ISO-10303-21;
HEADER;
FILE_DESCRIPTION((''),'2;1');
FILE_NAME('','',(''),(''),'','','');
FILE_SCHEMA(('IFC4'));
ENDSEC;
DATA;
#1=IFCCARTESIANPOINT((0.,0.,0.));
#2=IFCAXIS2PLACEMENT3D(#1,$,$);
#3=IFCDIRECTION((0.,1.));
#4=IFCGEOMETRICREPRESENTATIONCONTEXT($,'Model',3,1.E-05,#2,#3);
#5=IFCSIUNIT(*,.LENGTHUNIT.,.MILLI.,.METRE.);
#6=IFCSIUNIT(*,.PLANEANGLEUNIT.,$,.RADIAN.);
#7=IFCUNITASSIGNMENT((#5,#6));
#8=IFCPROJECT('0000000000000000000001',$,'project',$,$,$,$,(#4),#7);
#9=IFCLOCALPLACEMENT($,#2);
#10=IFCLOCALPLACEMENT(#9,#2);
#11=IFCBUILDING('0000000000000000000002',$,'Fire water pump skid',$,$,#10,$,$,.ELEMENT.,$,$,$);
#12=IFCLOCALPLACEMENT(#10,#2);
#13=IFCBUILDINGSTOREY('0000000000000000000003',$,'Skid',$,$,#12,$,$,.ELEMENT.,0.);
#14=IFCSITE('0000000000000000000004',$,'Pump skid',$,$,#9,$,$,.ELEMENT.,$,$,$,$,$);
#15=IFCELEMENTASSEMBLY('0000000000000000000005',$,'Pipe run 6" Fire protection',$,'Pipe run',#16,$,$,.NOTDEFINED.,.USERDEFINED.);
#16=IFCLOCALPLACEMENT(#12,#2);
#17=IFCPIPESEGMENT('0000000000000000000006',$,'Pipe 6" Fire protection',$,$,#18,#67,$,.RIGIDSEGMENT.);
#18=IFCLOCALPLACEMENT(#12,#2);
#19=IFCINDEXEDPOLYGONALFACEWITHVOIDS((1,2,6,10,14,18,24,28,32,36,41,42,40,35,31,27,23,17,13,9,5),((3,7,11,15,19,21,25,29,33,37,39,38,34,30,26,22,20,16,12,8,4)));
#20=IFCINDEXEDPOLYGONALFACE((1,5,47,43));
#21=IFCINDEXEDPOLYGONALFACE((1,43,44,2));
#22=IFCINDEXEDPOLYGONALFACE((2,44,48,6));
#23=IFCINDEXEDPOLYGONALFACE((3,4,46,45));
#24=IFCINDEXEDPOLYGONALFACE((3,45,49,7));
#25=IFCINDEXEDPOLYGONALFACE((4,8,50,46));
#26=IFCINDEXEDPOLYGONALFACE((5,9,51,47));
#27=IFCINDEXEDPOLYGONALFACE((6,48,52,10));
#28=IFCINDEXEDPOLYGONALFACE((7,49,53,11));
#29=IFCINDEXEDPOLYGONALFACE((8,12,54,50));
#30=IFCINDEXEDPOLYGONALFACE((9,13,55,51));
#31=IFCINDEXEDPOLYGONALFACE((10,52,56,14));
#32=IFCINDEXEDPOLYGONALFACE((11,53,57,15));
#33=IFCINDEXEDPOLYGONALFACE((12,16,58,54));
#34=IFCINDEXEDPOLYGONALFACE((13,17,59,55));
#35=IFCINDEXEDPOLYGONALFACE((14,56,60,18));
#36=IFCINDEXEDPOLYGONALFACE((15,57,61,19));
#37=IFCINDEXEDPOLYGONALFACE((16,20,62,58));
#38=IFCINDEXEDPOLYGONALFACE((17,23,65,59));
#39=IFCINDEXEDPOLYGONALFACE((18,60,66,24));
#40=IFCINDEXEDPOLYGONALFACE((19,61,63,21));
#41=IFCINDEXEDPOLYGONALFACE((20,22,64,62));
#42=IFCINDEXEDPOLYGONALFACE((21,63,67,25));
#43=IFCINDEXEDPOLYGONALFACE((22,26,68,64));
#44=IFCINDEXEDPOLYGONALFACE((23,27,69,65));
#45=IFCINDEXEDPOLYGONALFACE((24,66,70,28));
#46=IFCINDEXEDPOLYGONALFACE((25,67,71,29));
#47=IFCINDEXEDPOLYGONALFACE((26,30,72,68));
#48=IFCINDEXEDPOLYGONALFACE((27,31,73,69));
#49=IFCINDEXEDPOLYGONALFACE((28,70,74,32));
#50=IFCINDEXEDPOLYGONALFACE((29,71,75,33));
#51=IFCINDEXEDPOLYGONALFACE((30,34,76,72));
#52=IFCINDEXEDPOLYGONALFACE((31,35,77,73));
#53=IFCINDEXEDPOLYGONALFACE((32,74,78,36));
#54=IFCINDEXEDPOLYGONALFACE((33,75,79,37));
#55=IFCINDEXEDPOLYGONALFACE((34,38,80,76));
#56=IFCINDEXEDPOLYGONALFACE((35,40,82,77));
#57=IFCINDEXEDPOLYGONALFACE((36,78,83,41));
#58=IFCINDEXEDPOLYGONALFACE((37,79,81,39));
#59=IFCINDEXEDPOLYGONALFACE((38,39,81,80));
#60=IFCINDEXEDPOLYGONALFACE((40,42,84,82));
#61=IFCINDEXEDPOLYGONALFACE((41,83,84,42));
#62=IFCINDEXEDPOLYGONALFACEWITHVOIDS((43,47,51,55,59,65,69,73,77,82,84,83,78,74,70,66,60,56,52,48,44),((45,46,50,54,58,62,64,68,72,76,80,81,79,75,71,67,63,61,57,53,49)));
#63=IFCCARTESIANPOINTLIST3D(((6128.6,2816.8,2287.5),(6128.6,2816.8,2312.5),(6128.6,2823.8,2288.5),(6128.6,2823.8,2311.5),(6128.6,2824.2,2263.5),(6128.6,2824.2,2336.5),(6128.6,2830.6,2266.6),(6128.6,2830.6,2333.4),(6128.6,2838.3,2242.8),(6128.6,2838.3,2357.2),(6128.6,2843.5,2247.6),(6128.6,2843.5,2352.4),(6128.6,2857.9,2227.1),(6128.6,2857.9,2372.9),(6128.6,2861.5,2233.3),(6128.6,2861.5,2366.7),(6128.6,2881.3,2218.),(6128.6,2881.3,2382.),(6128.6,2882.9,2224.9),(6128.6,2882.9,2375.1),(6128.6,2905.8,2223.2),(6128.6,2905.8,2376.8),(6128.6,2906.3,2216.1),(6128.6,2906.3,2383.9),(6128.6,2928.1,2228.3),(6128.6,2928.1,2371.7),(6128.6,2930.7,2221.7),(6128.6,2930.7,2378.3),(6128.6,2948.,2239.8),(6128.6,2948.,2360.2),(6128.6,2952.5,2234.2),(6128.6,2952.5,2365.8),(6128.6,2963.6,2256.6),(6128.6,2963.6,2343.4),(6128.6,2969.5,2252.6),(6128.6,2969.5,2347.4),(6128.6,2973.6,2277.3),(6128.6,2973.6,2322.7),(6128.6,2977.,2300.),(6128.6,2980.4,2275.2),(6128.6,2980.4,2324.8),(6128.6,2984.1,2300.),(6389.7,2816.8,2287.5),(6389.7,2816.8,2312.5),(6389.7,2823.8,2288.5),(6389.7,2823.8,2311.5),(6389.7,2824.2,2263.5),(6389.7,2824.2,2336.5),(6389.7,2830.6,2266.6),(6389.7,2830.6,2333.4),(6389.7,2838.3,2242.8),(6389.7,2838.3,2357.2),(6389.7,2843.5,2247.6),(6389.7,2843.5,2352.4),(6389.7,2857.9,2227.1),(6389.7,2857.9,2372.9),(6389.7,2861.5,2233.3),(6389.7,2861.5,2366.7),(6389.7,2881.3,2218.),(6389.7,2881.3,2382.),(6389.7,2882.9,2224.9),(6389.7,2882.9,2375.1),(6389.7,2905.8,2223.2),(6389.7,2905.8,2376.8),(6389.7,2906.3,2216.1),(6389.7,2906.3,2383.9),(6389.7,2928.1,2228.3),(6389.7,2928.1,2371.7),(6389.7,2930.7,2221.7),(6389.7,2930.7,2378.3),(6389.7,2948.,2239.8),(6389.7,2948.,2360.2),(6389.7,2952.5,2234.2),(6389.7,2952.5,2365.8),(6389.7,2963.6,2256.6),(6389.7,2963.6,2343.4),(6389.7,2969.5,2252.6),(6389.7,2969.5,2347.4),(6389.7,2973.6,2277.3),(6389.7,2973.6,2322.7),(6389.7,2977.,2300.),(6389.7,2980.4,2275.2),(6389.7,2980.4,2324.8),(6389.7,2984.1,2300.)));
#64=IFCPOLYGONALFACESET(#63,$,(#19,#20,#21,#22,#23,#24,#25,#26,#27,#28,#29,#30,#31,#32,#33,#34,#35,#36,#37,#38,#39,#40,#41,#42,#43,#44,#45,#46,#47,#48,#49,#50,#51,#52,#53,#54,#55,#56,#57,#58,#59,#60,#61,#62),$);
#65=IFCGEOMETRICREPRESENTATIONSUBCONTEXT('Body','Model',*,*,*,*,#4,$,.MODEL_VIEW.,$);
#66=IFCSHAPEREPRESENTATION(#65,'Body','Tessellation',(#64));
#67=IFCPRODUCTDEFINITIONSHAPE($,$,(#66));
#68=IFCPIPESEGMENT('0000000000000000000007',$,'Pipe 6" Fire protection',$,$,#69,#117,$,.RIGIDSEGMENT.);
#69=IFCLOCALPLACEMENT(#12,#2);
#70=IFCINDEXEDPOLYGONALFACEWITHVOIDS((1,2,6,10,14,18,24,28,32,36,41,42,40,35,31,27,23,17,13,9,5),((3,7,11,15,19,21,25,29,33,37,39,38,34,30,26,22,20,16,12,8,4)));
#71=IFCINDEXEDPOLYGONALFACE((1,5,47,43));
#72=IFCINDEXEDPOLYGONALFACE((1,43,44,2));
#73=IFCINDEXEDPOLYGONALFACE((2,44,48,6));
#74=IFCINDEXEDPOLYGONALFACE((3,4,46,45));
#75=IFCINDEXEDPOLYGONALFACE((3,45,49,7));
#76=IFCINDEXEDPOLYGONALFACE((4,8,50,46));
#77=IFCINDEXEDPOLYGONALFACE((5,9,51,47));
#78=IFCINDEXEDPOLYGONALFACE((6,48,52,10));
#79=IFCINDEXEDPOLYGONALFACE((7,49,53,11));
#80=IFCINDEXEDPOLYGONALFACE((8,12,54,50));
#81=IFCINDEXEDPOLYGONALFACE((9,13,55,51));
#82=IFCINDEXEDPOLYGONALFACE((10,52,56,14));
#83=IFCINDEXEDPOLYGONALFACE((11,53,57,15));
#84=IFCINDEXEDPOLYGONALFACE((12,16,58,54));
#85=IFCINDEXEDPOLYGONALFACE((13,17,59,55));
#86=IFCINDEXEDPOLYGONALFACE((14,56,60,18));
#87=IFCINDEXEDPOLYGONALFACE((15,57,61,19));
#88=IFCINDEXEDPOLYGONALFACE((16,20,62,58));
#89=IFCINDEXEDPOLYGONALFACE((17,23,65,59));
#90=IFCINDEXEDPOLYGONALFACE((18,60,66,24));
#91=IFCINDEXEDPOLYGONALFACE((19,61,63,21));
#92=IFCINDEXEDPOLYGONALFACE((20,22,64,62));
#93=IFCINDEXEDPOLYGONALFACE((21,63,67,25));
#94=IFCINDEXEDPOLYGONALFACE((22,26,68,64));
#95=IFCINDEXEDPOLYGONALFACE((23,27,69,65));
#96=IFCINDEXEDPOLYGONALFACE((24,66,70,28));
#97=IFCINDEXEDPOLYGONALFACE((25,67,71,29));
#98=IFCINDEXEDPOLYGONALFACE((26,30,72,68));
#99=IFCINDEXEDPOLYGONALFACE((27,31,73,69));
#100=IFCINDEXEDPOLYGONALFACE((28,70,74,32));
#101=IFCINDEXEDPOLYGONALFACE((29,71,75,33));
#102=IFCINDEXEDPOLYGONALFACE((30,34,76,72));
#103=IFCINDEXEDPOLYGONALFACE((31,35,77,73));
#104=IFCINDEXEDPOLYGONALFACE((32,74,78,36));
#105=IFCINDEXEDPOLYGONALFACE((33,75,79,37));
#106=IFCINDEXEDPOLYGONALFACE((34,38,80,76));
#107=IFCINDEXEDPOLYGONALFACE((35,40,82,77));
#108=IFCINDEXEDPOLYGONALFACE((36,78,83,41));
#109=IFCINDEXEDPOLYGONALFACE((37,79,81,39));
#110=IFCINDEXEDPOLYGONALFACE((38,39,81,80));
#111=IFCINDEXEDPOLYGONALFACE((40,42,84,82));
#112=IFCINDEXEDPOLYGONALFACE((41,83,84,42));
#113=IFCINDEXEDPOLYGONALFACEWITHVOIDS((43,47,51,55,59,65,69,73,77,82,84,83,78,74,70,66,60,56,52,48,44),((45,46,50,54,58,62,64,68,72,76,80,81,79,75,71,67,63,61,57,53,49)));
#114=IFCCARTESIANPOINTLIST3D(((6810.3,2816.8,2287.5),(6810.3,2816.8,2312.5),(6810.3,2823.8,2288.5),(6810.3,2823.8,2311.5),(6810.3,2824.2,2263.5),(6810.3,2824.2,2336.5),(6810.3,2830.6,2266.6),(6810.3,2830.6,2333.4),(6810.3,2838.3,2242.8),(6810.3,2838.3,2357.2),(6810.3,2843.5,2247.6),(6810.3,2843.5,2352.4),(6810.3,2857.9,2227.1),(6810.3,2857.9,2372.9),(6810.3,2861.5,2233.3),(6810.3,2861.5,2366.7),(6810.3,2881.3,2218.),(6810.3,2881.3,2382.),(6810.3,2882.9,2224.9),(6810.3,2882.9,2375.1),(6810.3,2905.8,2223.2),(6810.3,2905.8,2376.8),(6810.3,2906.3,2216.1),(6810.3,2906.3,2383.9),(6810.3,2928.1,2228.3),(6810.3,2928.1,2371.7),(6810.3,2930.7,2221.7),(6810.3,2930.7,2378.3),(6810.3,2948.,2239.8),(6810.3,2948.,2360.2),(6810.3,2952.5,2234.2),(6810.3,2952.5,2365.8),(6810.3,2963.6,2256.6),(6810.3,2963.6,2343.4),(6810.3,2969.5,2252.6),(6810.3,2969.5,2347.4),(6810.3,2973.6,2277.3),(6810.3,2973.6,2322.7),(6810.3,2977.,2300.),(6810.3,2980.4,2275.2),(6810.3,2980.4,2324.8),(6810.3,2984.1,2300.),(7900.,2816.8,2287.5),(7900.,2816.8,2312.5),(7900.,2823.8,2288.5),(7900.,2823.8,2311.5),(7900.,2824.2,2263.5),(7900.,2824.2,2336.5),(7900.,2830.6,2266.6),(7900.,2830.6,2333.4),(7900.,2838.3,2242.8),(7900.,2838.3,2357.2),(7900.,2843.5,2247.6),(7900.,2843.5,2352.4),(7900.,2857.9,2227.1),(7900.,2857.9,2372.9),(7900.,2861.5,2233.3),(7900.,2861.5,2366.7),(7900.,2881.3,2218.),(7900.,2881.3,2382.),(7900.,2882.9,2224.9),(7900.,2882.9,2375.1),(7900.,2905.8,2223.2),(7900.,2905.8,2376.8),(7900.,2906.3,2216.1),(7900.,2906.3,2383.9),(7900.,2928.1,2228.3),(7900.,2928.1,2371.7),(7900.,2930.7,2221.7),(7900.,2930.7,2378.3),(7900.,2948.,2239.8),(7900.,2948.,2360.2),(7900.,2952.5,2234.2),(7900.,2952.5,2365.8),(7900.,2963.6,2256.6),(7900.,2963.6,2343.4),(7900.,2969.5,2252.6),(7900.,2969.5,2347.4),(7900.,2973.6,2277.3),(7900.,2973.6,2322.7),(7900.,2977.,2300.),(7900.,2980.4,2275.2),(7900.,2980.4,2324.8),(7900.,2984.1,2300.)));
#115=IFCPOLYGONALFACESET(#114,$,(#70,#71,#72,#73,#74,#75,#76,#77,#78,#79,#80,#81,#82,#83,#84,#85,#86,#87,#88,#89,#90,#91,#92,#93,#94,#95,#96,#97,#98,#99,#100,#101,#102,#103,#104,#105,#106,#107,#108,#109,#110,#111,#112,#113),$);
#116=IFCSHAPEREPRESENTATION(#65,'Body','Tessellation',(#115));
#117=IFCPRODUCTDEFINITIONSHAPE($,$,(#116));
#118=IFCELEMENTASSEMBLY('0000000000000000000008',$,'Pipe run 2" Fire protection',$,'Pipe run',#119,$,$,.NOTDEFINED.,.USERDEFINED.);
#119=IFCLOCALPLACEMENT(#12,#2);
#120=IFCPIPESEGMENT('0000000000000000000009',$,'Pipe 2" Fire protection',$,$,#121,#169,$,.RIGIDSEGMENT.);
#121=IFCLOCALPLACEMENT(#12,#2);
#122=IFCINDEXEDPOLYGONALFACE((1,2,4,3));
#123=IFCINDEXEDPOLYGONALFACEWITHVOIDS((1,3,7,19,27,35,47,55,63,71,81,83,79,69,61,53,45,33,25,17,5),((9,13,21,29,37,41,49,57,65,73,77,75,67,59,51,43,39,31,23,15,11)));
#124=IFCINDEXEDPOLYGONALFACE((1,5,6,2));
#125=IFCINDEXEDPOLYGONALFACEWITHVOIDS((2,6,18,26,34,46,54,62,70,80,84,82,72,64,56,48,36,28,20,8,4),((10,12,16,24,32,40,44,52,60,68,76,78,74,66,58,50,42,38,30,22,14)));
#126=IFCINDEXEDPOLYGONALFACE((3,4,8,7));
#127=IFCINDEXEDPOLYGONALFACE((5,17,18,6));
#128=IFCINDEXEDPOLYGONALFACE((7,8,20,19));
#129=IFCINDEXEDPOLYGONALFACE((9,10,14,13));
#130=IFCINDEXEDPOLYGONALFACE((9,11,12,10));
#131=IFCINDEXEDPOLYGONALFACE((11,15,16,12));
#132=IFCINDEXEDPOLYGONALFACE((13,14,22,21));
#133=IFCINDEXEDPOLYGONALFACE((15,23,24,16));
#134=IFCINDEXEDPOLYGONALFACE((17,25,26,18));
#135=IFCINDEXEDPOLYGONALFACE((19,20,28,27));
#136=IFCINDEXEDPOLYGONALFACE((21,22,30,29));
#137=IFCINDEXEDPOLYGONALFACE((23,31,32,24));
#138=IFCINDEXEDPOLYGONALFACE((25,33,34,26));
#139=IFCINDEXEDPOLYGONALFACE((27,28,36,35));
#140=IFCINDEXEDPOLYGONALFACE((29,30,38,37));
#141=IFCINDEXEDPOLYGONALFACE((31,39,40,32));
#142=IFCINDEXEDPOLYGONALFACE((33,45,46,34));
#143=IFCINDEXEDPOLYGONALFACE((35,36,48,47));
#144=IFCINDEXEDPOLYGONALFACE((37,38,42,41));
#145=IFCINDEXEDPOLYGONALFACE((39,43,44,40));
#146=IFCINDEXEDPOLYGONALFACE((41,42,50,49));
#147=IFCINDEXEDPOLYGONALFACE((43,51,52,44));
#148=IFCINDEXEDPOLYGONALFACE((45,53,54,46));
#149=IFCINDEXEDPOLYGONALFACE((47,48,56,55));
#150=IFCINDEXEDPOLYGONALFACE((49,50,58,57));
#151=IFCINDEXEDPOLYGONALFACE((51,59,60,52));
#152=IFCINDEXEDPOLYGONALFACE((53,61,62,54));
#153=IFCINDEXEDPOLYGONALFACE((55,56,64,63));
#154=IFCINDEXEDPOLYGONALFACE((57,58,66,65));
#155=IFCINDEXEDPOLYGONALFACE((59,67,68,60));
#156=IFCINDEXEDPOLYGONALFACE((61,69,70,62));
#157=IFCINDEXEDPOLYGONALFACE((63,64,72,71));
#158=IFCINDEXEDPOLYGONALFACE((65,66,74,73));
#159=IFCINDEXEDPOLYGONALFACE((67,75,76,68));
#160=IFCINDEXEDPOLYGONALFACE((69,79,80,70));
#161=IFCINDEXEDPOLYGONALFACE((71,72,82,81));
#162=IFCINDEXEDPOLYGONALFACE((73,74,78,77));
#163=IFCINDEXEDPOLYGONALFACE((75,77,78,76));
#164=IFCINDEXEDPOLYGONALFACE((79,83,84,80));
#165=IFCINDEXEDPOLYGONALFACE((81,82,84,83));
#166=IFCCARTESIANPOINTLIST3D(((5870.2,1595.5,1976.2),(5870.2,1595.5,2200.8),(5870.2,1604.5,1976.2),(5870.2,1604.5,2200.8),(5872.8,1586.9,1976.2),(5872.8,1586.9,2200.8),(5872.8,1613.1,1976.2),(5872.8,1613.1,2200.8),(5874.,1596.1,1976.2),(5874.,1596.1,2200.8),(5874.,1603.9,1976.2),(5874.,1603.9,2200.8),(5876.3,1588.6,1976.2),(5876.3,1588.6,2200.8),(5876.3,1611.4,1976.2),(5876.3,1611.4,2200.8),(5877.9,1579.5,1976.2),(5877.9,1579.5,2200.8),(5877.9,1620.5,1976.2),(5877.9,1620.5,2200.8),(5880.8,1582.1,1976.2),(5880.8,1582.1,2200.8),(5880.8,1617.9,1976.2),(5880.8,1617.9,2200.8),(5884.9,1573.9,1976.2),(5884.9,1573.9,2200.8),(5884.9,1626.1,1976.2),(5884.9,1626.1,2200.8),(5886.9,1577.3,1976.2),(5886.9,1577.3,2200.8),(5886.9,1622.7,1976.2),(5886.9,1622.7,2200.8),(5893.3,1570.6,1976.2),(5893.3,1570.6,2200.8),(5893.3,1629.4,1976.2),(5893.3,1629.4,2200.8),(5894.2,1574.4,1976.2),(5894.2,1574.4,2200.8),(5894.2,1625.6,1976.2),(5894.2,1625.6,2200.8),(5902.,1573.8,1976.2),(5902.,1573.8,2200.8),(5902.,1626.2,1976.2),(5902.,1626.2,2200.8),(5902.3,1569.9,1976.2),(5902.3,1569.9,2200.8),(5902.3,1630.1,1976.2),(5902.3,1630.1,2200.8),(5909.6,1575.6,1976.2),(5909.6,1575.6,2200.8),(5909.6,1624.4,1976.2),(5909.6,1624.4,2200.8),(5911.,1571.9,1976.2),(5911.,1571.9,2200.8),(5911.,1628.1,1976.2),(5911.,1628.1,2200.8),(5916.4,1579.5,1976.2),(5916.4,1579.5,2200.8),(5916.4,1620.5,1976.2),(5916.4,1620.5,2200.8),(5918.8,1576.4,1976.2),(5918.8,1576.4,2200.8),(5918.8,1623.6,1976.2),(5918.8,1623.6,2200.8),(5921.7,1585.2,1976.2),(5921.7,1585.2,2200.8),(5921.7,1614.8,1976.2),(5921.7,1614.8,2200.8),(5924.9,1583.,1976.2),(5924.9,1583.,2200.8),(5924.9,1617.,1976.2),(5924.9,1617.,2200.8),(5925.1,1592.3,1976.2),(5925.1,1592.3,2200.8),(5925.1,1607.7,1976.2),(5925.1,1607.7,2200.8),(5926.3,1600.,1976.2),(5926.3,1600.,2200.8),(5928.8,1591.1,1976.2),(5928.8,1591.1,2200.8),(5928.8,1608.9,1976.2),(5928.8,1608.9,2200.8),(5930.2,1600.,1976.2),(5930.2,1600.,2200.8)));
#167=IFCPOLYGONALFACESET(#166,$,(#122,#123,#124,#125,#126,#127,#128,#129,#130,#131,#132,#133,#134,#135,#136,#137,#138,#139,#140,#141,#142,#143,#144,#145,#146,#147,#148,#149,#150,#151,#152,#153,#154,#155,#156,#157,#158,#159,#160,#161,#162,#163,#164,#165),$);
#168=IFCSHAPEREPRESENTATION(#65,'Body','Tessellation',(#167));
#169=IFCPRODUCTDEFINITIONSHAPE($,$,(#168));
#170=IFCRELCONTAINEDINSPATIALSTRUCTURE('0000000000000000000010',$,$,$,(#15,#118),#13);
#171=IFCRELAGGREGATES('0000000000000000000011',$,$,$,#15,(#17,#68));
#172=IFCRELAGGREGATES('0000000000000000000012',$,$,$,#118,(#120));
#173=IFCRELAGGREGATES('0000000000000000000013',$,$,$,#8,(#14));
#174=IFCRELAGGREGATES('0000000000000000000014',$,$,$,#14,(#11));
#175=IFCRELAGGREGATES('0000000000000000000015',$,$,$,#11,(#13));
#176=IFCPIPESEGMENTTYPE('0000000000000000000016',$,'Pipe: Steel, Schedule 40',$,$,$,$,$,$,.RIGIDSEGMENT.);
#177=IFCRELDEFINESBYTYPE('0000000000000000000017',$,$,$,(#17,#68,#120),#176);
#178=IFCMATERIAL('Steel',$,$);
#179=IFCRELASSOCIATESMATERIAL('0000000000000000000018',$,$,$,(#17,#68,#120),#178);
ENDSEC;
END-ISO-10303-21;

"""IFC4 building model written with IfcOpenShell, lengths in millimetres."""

from ifc_helpers import new_model, si_unit, direction, frame, origin, origin_with_axes, origin_2d, place, context, subcontext, project, spatial, hollow_circle, extrude, material, type_object, element, aggregate, save


model = new_model("IFC4")

# Units and contexts
model_context = context("Model", 3, precision=1e-05, world=origin(), true_north=direction((0.0, 1.0)))
body_context = subcontext(model_context, "Body", "Model", "MODEL_VIEW")
ifc_project = project(units=[si_unit("LENGTHUNIT", "METRE", prefix="MILLI"), si_unit("PLANEANGLEUNIT", "RADIAN")], contexts=[model_context])

# Site, building, storey
site_placement = place(None, origin())
site = spatial("IfcSite", under=ifc_project, at=site_placement, Name="Pump skid", CompositionType="ELEMENT")
building_placement = place(site_placement, origin())
building = spatial("IfcBuilding", under=site, at=building_placement, Name="Fire water pump skid", CompositionType="ELEMENT")
storey_placement = place(building_placement, origin())
storey = spatial("IfcBuildingStorey", under=building, at=storey_placement, Name="Skid", CompositionType="ELEMENT", Elevation=0.0)

# Element assemblies, pipe segments
ifc_material = material(Name="Steel")
pipe_segment_type = type_object("IfcPipeSegmentType", Name="Pipe: Steel, Schedule 40", PredefinedType="RIGIDSEGMENT")
assembly_1_placement = place(storey_placement, origin_with_axes())
assembly_1 = element("IfcElementAssembly", 1, at=assembly_1_placement, inside=storey, Name="Pipe run 6\" Fire protection", ObjectType="Pipe run", AssemblyPlace="NOTDEFINED", PredefinedType="USERDEFINED")
pipe_segment_1_placement = place(storey_placement, origin_with_axes())
pipe_segment_1 = element("IfcPipeSegment", 2, at=pipe_segment_1_placement, type_object=pipe_segment_type, material=ifc_material, Name="Pipe 6\" Fire protection", PredefinedType="RIGIDSEGMENT", context=body_context, shape_type="SweptSolid", body=[
    extrude(hollow_circle(Radius=84.1, WallThickness=7.1, at=origin_2d()), frame((6128.6, 2900.0, 2300.0), z_axis=(1.0, 0.0, 0.0), x_axis=(0.0, 1.0, 0.0)), (0.0, 0.0, 1.0), 261.1),
])
pipe_segment_2_placement = place(storey_placement, origin_with_axes())
pipe_segment_2 = element("IfcPipeSegment", 3, at=pipe_segment_2_placement, type_object=pipe_segment_type, material=ifc_material, Name="Pipe 6\" Fire protection", PredefinedType="RIGIDSEGMENT", context=body_context, shape_type="SweptSolid", body=[
    extrude(hollow_circle(Radius=84.1, WallThickness=7.1, at=origin_2d()), frame((6810.3, 2900.0, 2300.0), z_axis=(1.0, 0.0, 0.0), x_axis=(0.0, 1.0, 0.0)), (0.0, 0.0, 1.0), 1089.7),
])
assembly_2_placement = place(storey_placement, origin_with_axes())
assembly_2 = element("IfcElementAssembly", 4, at=assembly_2_placement, inside=storey, Name="Pipe run 2\" Fire protection", ObjectType="Pipe run", AssemblyPlace="NOTDEFINED", PredefinedType="USERDEFINED")
pipe_segment_3_placement = place(storey_placement, origin_with_axes())
pipe_segment_3 = element("IfcPipeSegment", 5, at=pipe_segment_3_placement, type_object=pipe_segment_type, material=ifc_material, Name="Pipe 2\" Fire protection", PredefinedType="RIGIDSEGMENT", context=body_context, shape_type="SweptSolid", body=[
    extrude(hollow_circle(Radius=30.2, WallThickness=3.9, at=origin_2d()), frame((5900.0, 1600.0, 2200.8), z_axis=(0.0, 0.0, -1.0), x_axis=(1.0, 0.0, 0.0)), (0.0, 0.0, 1.0), 224.6),
])

aggregate(assembly_1, [pipe_segment_1, pipe_segment_2])

aggregate(assembly_2, [pipe_segment_3])

save(model, "model.ifc")
